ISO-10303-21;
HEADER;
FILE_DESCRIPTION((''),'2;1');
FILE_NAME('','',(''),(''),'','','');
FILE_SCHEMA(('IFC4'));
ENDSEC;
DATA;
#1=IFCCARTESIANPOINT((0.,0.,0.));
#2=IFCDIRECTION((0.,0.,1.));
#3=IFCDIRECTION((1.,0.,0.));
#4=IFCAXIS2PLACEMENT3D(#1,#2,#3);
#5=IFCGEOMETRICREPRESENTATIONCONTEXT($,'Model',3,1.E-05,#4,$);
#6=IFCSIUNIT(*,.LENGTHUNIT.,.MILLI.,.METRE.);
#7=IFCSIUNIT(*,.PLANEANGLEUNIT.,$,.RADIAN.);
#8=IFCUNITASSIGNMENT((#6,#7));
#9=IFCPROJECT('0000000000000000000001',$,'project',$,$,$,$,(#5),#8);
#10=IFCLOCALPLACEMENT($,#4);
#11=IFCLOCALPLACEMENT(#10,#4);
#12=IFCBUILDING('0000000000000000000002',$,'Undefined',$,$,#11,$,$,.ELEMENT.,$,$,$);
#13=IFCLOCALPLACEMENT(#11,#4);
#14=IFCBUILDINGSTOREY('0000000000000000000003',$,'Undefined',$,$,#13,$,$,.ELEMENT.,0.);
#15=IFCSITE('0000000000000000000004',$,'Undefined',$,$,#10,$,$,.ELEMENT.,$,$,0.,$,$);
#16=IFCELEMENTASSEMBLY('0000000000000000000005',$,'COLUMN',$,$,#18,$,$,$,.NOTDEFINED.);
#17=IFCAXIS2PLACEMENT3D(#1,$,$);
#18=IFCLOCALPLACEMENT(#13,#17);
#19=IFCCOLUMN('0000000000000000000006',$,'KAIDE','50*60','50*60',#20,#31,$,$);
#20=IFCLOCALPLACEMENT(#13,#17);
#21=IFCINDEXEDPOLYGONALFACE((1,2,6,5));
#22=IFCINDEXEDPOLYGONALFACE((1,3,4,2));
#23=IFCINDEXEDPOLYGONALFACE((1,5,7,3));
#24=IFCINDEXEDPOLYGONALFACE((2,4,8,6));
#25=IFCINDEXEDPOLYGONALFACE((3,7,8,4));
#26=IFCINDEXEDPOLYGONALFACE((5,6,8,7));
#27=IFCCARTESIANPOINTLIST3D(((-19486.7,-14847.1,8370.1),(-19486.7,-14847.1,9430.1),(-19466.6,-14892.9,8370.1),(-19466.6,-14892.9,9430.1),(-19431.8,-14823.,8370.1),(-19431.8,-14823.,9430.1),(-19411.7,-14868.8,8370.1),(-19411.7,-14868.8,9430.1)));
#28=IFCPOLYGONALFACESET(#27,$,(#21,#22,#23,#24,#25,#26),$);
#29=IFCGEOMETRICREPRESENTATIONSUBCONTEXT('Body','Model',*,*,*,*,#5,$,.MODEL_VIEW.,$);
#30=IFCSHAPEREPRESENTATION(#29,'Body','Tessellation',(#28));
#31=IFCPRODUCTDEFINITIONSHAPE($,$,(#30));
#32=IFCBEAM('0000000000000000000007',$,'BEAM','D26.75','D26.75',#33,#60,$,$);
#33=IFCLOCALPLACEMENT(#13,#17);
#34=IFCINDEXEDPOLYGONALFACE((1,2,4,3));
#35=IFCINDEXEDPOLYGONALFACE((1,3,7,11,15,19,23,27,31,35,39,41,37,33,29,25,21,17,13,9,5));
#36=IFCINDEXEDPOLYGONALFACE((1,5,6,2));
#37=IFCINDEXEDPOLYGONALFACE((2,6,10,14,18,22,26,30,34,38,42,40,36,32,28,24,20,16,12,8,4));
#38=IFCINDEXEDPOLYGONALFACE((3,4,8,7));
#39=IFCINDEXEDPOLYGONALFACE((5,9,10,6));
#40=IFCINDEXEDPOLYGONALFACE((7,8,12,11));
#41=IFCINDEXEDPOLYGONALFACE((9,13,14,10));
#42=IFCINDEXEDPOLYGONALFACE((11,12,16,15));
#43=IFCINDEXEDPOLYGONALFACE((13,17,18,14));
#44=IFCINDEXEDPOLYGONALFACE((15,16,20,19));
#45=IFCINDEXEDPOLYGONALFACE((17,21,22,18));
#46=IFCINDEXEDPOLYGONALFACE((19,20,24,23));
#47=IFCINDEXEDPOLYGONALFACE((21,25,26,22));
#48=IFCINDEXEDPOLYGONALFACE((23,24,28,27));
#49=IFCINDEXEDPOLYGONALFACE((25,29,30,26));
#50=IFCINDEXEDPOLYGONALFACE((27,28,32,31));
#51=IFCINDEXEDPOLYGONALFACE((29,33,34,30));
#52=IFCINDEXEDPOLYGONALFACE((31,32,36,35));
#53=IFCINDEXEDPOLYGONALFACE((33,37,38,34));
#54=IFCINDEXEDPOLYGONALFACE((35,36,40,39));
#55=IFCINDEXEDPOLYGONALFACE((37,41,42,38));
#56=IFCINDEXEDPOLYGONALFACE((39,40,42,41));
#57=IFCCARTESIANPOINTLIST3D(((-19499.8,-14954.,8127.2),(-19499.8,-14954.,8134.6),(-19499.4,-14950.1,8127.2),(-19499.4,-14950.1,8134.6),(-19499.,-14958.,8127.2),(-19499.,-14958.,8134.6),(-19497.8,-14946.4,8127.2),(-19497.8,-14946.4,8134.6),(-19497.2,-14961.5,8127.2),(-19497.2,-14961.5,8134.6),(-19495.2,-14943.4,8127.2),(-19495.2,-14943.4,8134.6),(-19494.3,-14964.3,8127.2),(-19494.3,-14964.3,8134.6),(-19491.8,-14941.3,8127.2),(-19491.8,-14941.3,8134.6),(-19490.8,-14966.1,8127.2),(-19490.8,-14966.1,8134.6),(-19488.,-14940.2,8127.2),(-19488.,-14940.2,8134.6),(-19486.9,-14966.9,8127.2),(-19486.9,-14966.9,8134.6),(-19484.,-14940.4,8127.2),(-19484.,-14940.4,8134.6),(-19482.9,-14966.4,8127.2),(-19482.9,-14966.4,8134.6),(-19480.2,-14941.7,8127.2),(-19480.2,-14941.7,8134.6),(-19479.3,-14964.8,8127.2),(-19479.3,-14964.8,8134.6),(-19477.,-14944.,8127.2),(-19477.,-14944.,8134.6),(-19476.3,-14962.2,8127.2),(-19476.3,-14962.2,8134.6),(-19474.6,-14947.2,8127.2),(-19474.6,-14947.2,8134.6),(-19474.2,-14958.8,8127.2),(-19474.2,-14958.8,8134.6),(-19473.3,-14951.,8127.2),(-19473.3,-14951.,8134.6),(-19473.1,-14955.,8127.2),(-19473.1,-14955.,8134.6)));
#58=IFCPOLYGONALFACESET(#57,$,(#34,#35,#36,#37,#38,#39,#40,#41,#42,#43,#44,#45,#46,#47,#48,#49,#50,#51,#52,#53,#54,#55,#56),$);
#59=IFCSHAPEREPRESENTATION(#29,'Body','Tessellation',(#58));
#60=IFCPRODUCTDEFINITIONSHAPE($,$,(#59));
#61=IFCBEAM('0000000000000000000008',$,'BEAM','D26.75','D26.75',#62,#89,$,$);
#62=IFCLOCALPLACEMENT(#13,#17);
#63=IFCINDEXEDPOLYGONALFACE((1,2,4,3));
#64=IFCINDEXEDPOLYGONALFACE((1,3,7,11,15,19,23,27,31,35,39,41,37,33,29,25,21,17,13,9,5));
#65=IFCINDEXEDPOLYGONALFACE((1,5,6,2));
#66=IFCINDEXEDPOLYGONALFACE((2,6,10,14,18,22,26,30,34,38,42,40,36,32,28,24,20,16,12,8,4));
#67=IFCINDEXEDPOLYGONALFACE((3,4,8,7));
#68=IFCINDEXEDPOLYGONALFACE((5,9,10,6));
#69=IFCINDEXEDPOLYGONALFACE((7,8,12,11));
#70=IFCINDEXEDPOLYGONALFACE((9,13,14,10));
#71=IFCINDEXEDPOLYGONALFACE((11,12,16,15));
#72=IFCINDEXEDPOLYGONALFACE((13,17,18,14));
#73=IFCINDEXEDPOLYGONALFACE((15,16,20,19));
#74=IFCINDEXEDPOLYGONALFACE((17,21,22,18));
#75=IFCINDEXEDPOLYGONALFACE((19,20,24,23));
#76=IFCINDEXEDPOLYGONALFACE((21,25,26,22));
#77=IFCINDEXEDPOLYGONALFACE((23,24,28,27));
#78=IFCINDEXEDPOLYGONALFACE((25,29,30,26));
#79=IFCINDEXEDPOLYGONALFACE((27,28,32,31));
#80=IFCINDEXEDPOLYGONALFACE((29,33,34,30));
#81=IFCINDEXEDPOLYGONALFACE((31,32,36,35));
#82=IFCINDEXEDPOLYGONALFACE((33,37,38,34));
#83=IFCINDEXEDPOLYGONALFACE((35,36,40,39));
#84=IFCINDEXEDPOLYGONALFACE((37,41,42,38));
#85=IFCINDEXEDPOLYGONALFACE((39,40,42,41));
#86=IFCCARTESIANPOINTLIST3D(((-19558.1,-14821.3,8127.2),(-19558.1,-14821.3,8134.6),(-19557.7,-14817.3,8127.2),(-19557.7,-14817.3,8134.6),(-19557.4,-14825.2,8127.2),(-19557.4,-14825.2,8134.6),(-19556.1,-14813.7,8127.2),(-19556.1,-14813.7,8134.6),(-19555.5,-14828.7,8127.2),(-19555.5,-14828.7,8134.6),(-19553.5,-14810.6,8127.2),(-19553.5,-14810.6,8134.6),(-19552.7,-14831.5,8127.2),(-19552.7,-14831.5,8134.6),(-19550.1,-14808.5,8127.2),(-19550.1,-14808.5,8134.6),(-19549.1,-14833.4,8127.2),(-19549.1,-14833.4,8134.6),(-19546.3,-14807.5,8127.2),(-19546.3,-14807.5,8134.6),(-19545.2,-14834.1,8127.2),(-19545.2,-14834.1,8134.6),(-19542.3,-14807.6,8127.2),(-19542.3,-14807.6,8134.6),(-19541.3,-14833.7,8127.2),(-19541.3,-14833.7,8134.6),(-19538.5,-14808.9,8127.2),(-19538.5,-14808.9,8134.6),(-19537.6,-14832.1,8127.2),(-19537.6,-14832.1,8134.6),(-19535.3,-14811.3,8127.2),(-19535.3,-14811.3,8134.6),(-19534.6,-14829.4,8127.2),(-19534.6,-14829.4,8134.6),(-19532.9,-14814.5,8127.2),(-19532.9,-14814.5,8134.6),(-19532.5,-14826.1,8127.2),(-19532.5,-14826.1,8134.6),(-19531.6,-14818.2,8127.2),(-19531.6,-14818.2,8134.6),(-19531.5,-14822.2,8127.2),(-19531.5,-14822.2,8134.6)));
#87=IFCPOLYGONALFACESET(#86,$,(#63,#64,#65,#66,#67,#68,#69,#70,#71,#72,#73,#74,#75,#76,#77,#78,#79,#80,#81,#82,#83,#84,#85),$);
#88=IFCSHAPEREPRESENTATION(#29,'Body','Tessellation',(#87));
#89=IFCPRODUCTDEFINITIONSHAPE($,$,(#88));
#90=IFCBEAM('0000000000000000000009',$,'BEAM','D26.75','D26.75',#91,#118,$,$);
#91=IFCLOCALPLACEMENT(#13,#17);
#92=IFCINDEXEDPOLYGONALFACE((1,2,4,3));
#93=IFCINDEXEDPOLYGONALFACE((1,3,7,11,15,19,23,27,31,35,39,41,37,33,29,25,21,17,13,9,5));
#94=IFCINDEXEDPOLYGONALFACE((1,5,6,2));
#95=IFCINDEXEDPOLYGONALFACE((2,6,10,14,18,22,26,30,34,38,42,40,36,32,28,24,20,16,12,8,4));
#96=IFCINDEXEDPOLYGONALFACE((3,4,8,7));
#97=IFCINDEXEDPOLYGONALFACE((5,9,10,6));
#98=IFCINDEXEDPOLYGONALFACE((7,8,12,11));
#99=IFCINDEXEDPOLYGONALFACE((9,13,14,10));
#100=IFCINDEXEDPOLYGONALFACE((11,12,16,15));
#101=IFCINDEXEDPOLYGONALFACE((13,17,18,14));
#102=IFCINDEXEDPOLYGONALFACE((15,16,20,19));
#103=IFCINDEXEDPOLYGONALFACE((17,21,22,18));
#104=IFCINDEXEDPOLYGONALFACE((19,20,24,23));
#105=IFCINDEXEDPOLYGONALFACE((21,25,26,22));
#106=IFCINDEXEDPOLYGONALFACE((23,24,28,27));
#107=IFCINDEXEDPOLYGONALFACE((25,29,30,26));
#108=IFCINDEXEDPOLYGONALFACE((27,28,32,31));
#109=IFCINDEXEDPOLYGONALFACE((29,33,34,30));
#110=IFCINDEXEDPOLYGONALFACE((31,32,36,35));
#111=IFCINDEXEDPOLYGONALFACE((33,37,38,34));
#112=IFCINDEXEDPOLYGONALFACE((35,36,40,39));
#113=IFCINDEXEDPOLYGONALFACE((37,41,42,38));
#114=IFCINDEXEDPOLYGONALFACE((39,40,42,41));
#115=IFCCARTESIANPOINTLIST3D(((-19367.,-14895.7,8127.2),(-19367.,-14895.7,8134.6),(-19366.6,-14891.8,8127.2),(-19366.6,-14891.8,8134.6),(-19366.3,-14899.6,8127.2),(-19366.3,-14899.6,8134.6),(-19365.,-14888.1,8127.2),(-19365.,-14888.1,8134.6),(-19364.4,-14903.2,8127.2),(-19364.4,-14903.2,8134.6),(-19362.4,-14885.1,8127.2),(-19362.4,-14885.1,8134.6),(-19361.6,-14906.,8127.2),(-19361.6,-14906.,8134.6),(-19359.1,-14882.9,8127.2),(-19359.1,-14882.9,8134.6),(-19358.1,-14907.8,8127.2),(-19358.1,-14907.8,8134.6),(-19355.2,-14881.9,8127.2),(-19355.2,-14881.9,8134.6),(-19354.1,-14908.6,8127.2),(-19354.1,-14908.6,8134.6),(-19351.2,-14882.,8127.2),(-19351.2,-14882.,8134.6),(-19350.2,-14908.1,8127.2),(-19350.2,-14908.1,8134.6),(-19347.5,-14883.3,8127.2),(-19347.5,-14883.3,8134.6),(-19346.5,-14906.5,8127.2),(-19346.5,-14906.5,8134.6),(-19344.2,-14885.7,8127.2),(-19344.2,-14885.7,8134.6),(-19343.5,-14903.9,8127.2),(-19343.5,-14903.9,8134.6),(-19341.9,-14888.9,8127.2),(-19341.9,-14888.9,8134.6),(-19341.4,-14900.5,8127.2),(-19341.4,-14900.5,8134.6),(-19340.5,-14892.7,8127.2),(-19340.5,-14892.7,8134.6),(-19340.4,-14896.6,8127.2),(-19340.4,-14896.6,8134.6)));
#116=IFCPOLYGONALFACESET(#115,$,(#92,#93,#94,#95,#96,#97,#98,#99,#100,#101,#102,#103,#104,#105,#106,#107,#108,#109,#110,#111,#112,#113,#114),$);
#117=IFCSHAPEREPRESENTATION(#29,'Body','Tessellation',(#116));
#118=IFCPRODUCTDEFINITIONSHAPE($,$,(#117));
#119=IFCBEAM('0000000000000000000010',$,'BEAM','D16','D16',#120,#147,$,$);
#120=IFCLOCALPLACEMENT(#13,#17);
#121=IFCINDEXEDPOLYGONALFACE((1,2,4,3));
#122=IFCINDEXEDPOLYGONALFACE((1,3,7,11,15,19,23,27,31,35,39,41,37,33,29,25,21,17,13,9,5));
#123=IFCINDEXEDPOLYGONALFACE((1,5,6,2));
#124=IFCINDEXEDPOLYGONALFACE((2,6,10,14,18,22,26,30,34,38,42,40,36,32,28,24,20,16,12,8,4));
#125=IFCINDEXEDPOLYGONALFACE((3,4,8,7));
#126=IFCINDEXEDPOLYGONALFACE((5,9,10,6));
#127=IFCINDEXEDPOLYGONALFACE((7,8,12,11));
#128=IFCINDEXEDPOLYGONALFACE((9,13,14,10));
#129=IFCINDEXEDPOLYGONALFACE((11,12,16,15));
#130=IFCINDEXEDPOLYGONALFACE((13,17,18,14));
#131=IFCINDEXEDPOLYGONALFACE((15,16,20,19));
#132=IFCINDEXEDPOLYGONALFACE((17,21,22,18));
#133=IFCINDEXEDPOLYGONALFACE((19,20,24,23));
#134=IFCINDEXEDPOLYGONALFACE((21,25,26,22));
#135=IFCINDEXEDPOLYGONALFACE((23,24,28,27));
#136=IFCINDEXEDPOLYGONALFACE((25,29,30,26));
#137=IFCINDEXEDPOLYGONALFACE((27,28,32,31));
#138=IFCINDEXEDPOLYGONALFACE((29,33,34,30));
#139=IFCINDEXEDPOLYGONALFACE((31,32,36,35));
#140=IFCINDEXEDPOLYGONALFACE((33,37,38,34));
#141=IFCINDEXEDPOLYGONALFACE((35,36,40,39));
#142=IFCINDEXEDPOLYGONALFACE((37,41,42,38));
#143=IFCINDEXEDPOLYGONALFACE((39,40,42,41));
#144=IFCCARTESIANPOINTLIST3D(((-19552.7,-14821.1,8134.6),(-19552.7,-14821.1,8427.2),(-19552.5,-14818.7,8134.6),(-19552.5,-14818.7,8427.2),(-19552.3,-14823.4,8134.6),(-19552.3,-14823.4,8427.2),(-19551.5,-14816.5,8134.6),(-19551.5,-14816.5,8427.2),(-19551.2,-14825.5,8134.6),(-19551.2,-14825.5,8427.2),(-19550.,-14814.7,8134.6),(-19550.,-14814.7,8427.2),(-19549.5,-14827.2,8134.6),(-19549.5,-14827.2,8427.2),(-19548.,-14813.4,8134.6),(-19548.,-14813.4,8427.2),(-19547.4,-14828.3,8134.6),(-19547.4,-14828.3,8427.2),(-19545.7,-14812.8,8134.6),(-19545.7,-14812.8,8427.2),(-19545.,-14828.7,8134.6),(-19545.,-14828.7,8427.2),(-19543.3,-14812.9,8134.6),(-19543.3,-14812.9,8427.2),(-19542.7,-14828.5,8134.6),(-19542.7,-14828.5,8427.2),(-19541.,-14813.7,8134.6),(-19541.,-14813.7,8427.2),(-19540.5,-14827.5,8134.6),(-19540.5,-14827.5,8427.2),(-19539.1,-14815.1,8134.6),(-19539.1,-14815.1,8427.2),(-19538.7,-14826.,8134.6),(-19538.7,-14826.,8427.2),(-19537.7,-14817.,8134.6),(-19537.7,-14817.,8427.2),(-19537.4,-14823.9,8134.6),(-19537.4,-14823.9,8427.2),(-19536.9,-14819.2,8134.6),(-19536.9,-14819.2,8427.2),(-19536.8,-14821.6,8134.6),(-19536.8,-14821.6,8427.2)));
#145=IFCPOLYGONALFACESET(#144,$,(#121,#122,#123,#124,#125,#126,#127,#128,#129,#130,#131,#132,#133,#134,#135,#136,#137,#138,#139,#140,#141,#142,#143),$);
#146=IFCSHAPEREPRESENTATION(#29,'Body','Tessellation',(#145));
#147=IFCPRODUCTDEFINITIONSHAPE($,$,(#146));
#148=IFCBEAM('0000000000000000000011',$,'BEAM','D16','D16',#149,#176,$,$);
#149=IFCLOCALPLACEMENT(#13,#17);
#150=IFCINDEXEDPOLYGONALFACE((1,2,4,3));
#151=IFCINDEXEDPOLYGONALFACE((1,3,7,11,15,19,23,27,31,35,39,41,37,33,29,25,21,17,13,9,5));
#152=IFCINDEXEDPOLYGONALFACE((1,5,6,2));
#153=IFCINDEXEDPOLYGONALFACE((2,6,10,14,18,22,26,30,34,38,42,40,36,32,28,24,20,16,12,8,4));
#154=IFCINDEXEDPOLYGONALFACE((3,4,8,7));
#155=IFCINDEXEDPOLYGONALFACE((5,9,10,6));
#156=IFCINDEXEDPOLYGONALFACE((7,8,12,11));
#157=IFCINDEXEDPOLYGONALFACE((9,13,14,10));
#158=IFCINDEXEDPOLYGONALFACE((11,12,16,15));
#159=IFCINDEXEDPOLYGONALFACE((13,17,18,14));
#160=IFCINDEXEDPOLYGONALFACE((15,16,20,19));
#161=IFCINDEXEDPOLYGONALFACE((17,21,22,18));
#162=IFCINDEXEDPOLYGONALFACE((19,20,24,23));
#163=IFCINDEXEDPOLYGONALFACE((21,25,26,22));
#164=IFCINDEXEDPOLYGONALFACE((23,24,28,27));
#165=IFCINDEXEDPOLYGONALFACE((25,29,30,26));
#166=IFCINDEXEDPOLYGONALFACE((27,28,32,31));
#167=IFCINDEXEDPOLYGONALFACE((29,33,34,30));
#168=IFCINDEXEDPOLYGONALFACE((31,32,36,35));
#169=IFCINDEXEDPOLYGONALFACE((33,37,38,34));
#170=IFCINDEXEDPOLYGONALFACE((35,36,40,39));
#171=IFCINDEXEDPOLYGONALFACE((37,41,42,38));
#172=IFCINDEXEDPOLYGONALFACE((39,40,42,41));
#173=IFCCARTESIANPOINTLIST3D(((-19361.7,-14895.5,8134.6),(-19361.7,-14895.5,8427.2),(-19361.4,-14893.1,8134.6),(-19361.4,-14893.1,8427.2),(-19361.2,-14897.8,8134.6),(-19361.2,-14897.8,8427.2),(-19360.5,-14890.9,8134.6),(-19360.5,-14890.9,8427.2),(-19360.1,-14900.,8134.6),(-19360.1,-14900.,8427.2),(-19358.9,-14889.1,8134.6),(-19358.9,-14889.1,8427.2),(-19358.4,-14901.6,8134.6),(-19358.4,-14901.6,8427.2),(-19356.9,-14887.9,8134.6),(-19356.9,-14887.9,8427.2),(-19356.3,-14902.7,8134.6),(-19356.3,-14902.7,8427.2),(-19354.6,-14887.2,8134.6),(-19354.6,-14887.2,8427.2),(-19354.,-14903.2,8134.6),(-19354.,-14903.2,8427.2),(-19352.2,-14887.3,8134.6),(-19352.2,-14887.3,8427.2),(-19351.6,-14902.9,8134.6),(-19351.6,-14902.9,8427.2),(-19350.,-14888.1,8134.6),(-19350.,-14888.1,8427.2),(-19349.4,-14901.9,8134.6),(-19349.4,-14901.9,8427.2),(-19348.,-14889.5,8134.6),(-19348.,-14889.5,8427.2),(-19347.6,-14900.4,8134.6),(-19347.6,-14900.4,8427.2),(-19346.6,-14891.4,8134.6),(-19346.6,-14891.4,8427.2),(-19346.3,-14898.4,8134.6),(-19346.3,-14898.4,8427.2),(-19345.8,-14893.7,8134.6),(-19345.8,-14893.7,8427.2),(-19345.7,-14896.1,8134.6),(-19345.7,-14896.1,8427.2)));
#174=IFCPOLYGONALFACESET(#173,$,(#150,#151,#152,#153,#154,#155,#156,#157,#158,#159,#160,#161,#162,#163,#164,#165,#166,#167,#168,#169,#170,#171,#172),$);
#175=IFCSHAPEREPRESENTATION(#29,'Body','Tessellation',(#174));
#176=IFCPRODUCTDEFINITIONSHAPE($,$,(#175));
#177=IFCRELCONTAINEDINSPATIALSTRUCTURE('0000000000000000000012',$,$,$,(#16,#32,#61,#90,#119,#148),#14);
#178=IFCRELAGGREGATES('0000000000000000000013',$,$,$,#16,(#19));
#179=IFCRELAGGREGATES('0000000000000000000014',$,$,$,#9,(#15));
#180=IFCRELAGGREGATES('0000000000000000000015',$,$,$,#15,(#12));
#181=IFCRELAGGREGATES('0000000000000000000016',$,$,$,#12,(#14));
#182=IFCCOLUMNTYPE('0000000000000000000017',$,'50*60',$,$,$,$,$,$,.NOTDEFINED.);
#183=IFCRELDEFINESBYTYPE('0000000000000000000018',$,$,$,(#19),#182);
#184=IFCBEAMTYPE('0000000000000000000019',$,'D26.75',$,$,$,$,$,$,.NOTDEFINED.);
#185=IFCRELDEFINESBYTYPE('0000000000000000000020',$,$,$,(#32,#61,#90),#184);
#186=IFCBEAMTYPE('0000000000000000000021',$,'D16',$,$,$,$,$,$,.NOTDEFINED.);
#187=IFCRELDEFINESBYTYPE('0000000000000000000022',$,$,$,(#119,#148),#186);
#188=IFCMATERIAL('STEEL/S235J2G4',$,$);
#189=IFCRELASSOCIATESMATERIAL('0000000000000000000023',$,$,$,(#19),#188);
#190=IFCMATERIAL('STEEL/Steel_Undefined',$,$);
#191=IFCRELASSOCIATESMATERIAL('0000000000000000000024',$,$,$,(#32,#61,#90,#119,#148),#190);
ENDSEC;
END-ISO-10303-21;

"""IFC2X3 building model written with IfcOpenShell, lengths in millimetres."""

from ifc_helpers import new_model, si_unit, frame, origin_with_axes, origin_2d_with_axis, place, context, subcontext, project, spatial, rectangle, circle, extrude, material, type_object, element, aggregate, save


model = new_model("IFC2X3")

# Units and contexts
model_context = context("Model", 3, precision=1e-05, world=origin_with_axes())
body_context = subcontext(model_context, "Body", "Model", "MODEL_VIEW")
ifc_project = project(units=[si_unit("LENGTHUNIT", "METRE", prefix="MILLI"), si_unit("PLANEANGLEUNIT", "RADIAN")], contexts=[model_context])

# Site, building, storey
site_placement = place(None, origin_with_axes())
site = spatial("IfcSite", under=ifc_project, at=site_placement, Name="Undefined", CompositionType="ELEMENT", RefElevation=0.0)
building_placement = place(site_placement, origin_with_axes())
building = spatial("IfcBuilding", under=site, at=building_placement, Name="Undefined", CompositionType="ELEMENT")
storey_placement = place(building_placement, origin_with_axes())
storey = spatial("IfcBuildingStorey", under=building, at=storey_placement, Name="Undefined", CompositionType="ELEMENT", Elevation=0.0)

# Element assembly, column
assembly_placement = place(storey_placement, frame((-19449.2, -14858.0, 8370.1), z_axis=(-0.402197, 0.915553, 0.0), x_axis=(0.0, 0.0, 1.0)))
assembly = element("IfcElementAssembly", 1, at=assembly_placement, inside=storey, Name="COLUMN", PredefinedType="NOTDEFINED")
ifc_material_1 = material(Name="STEEL/S235J2G4")
column_type = type_object("IfcColumnType", Name="50*60", PredefinedType="NOTDEFINED")
column_placement = place(storey_placement, frame((-19449.2, -14858.0, 8370.1), z_axis=(0.0, 0.0, 1.0), x_axis=(1.0, 0.0, 0.0)))
column = element("IfcColumn", 2, at=column_placement, type_object=column_type, material=ifc_material_1, Name="KAIDE", Description="50*60", ObjectType="50*60", context=body_context, shape_type="SweptSolid", body=[
    extrude(rectangle(XDim=60.0, YDim=50.0, at=origin_2d_with_axis()), frame((0.0, 0.0, 1060.0), z_axis=(0.0, 0.0, -1.0), x_axis=(-0.915553, -0.402197, 0.0)), (0.0, 0.0, 1.0), 1060.0),
])
aggregate(assembly, [column])

# Beam
ifc_material_2 = material(Name="STEEL/Steel_Undefined")
beam_type_1 = type_object("IfcBeamType", Name="D26.75", PredefinedType="NOTDEFINED")
beam_1_placement = place(storey_placement, frame((-19486.4, -14953.5, 8134.6), z_axis=(-0.915553, -0.402197, 0.0), x_axis=(0.0, 0.0, -1.0)))
element("IfcBeam", 3, at=beam_1_placement, inside=storey, type_object=beam_type_1, material=ifc_material_2, Name="BEAM", Description="D26.75", ObjectType="D26.75", context=body_context, shape_type="SweptSolid", body=[
    extrude(circle(Radius=13.4, at=origin_2d_with_axis()), frame((7.4, 0.0, 0.0), z_axis=(-1.0, 0.0, 0.0), x_axis=(0.0, -1.0, 0.0)), (0.0, 0.0, 1.0), 7.4),
])

# Beam
beam_2_placement = place(storey_placement, frame((-19544.8, -14820.7, 8134.6), z_axis=(-0.915553, -0.402197, 0.0), x_axis=(0.0, 0.0, -1.0)))
element("IfcBeam", 4, at=beam_2_placement, inside=storey, type_object=beam_type_1, material=ifc_material_2, Name="BEAM", Description="D26.75", ObjectType="D26.75", context=body_context, shape_type="SweptSolid", body=[
    extrude(circle(Radius=13.4, at=origin_2d_with_axis()), frame((7.4, 0.0, 0.0), z_axis=(-1.0, 0.0, 0.0), x_axis=(0.0, -1.0, 0.0)), (0.0, 0.0, 1.0), 7.4),
])

# Beam
beam_3_placement = place(storey_placement, frame((-19353.7, -14895.2, 8134.6), z_axis=(-0.915553, -0.402197, 0.0), x_axis=(0.0, 0.0, -1.0)))
element("IfcBeam", 5, at=beam_3_placement, inside=storey, type_object=beam_type_1, material=ifc_material_2, Name="BEAM", Description="D26.75", ObjectType="D26.75", context=body_context, shape_type="SweptSolid", body=[
    extrude(circle(Radius=13.4, at=origin_2d_with_axis()), frame((7.4, 0.0, 0.0), z_axis=(-1.0, 0.0, 0.0), x_axis=(0.0, -1.0, 0.0)), (0.0, 0.0, 1.0), 7.4),
])

# Beams
beam_type_2 = type_object("IfcBeamType", Name="D16", PredefinedType="NOTDEFINED")
beam_4_placement = place(storey_placement, frame((-19544.8, -14820.7, 8427.2), z_axis=(-0.915553, -0.402197, 0.0), x_axis=(0.0, 0.0, -1.0)))
element("IfcBeam", 6, at=beam_4_placement, inside=storey, type_object=beam_type_2, material=ifc_material_2, Name="BEAM", Description="D16", ObjectType="D16", context=body_context, shape_type="SweptSolid", body=[
    extrude(circle(Radius=8.0, at=origin_2d_with_axis()), frame((292.6, 0.0, 0.0), z_axis=(-1.0, 0.0, 0.0), x_axis=(0.0, -1.0, 0.0)), (0.0, 0.0, 1.0), 292.6),
])
beam_5_placement = place(storey_placement, frame((-19353.7, -14895.2, 8427.2), z_axis=(-0.915553, -0.402197, 0.0), x_axis=(0.0, 0.0, -1.0)))
element("IfcBeam", 7, at=beam_5_placement, inside=storey, type_object=beam_type_2, material=ifc_material_2, Name="BEAM", Description="D16", ObjectType="D16", context=body_context, shape_type="SweptSolid", body=[
    extrude(circle(Radius=8.0, at=origin_2d_with_axis()), frame((292.6, 0.0, 0.0), z_axis=(-1.0, 0.0, 0.0), x_axis=(0.0, -1.0, 0.0)), (0.0, 0.0, 1.0), 292.6),
])

save(model, "model.ifc")
